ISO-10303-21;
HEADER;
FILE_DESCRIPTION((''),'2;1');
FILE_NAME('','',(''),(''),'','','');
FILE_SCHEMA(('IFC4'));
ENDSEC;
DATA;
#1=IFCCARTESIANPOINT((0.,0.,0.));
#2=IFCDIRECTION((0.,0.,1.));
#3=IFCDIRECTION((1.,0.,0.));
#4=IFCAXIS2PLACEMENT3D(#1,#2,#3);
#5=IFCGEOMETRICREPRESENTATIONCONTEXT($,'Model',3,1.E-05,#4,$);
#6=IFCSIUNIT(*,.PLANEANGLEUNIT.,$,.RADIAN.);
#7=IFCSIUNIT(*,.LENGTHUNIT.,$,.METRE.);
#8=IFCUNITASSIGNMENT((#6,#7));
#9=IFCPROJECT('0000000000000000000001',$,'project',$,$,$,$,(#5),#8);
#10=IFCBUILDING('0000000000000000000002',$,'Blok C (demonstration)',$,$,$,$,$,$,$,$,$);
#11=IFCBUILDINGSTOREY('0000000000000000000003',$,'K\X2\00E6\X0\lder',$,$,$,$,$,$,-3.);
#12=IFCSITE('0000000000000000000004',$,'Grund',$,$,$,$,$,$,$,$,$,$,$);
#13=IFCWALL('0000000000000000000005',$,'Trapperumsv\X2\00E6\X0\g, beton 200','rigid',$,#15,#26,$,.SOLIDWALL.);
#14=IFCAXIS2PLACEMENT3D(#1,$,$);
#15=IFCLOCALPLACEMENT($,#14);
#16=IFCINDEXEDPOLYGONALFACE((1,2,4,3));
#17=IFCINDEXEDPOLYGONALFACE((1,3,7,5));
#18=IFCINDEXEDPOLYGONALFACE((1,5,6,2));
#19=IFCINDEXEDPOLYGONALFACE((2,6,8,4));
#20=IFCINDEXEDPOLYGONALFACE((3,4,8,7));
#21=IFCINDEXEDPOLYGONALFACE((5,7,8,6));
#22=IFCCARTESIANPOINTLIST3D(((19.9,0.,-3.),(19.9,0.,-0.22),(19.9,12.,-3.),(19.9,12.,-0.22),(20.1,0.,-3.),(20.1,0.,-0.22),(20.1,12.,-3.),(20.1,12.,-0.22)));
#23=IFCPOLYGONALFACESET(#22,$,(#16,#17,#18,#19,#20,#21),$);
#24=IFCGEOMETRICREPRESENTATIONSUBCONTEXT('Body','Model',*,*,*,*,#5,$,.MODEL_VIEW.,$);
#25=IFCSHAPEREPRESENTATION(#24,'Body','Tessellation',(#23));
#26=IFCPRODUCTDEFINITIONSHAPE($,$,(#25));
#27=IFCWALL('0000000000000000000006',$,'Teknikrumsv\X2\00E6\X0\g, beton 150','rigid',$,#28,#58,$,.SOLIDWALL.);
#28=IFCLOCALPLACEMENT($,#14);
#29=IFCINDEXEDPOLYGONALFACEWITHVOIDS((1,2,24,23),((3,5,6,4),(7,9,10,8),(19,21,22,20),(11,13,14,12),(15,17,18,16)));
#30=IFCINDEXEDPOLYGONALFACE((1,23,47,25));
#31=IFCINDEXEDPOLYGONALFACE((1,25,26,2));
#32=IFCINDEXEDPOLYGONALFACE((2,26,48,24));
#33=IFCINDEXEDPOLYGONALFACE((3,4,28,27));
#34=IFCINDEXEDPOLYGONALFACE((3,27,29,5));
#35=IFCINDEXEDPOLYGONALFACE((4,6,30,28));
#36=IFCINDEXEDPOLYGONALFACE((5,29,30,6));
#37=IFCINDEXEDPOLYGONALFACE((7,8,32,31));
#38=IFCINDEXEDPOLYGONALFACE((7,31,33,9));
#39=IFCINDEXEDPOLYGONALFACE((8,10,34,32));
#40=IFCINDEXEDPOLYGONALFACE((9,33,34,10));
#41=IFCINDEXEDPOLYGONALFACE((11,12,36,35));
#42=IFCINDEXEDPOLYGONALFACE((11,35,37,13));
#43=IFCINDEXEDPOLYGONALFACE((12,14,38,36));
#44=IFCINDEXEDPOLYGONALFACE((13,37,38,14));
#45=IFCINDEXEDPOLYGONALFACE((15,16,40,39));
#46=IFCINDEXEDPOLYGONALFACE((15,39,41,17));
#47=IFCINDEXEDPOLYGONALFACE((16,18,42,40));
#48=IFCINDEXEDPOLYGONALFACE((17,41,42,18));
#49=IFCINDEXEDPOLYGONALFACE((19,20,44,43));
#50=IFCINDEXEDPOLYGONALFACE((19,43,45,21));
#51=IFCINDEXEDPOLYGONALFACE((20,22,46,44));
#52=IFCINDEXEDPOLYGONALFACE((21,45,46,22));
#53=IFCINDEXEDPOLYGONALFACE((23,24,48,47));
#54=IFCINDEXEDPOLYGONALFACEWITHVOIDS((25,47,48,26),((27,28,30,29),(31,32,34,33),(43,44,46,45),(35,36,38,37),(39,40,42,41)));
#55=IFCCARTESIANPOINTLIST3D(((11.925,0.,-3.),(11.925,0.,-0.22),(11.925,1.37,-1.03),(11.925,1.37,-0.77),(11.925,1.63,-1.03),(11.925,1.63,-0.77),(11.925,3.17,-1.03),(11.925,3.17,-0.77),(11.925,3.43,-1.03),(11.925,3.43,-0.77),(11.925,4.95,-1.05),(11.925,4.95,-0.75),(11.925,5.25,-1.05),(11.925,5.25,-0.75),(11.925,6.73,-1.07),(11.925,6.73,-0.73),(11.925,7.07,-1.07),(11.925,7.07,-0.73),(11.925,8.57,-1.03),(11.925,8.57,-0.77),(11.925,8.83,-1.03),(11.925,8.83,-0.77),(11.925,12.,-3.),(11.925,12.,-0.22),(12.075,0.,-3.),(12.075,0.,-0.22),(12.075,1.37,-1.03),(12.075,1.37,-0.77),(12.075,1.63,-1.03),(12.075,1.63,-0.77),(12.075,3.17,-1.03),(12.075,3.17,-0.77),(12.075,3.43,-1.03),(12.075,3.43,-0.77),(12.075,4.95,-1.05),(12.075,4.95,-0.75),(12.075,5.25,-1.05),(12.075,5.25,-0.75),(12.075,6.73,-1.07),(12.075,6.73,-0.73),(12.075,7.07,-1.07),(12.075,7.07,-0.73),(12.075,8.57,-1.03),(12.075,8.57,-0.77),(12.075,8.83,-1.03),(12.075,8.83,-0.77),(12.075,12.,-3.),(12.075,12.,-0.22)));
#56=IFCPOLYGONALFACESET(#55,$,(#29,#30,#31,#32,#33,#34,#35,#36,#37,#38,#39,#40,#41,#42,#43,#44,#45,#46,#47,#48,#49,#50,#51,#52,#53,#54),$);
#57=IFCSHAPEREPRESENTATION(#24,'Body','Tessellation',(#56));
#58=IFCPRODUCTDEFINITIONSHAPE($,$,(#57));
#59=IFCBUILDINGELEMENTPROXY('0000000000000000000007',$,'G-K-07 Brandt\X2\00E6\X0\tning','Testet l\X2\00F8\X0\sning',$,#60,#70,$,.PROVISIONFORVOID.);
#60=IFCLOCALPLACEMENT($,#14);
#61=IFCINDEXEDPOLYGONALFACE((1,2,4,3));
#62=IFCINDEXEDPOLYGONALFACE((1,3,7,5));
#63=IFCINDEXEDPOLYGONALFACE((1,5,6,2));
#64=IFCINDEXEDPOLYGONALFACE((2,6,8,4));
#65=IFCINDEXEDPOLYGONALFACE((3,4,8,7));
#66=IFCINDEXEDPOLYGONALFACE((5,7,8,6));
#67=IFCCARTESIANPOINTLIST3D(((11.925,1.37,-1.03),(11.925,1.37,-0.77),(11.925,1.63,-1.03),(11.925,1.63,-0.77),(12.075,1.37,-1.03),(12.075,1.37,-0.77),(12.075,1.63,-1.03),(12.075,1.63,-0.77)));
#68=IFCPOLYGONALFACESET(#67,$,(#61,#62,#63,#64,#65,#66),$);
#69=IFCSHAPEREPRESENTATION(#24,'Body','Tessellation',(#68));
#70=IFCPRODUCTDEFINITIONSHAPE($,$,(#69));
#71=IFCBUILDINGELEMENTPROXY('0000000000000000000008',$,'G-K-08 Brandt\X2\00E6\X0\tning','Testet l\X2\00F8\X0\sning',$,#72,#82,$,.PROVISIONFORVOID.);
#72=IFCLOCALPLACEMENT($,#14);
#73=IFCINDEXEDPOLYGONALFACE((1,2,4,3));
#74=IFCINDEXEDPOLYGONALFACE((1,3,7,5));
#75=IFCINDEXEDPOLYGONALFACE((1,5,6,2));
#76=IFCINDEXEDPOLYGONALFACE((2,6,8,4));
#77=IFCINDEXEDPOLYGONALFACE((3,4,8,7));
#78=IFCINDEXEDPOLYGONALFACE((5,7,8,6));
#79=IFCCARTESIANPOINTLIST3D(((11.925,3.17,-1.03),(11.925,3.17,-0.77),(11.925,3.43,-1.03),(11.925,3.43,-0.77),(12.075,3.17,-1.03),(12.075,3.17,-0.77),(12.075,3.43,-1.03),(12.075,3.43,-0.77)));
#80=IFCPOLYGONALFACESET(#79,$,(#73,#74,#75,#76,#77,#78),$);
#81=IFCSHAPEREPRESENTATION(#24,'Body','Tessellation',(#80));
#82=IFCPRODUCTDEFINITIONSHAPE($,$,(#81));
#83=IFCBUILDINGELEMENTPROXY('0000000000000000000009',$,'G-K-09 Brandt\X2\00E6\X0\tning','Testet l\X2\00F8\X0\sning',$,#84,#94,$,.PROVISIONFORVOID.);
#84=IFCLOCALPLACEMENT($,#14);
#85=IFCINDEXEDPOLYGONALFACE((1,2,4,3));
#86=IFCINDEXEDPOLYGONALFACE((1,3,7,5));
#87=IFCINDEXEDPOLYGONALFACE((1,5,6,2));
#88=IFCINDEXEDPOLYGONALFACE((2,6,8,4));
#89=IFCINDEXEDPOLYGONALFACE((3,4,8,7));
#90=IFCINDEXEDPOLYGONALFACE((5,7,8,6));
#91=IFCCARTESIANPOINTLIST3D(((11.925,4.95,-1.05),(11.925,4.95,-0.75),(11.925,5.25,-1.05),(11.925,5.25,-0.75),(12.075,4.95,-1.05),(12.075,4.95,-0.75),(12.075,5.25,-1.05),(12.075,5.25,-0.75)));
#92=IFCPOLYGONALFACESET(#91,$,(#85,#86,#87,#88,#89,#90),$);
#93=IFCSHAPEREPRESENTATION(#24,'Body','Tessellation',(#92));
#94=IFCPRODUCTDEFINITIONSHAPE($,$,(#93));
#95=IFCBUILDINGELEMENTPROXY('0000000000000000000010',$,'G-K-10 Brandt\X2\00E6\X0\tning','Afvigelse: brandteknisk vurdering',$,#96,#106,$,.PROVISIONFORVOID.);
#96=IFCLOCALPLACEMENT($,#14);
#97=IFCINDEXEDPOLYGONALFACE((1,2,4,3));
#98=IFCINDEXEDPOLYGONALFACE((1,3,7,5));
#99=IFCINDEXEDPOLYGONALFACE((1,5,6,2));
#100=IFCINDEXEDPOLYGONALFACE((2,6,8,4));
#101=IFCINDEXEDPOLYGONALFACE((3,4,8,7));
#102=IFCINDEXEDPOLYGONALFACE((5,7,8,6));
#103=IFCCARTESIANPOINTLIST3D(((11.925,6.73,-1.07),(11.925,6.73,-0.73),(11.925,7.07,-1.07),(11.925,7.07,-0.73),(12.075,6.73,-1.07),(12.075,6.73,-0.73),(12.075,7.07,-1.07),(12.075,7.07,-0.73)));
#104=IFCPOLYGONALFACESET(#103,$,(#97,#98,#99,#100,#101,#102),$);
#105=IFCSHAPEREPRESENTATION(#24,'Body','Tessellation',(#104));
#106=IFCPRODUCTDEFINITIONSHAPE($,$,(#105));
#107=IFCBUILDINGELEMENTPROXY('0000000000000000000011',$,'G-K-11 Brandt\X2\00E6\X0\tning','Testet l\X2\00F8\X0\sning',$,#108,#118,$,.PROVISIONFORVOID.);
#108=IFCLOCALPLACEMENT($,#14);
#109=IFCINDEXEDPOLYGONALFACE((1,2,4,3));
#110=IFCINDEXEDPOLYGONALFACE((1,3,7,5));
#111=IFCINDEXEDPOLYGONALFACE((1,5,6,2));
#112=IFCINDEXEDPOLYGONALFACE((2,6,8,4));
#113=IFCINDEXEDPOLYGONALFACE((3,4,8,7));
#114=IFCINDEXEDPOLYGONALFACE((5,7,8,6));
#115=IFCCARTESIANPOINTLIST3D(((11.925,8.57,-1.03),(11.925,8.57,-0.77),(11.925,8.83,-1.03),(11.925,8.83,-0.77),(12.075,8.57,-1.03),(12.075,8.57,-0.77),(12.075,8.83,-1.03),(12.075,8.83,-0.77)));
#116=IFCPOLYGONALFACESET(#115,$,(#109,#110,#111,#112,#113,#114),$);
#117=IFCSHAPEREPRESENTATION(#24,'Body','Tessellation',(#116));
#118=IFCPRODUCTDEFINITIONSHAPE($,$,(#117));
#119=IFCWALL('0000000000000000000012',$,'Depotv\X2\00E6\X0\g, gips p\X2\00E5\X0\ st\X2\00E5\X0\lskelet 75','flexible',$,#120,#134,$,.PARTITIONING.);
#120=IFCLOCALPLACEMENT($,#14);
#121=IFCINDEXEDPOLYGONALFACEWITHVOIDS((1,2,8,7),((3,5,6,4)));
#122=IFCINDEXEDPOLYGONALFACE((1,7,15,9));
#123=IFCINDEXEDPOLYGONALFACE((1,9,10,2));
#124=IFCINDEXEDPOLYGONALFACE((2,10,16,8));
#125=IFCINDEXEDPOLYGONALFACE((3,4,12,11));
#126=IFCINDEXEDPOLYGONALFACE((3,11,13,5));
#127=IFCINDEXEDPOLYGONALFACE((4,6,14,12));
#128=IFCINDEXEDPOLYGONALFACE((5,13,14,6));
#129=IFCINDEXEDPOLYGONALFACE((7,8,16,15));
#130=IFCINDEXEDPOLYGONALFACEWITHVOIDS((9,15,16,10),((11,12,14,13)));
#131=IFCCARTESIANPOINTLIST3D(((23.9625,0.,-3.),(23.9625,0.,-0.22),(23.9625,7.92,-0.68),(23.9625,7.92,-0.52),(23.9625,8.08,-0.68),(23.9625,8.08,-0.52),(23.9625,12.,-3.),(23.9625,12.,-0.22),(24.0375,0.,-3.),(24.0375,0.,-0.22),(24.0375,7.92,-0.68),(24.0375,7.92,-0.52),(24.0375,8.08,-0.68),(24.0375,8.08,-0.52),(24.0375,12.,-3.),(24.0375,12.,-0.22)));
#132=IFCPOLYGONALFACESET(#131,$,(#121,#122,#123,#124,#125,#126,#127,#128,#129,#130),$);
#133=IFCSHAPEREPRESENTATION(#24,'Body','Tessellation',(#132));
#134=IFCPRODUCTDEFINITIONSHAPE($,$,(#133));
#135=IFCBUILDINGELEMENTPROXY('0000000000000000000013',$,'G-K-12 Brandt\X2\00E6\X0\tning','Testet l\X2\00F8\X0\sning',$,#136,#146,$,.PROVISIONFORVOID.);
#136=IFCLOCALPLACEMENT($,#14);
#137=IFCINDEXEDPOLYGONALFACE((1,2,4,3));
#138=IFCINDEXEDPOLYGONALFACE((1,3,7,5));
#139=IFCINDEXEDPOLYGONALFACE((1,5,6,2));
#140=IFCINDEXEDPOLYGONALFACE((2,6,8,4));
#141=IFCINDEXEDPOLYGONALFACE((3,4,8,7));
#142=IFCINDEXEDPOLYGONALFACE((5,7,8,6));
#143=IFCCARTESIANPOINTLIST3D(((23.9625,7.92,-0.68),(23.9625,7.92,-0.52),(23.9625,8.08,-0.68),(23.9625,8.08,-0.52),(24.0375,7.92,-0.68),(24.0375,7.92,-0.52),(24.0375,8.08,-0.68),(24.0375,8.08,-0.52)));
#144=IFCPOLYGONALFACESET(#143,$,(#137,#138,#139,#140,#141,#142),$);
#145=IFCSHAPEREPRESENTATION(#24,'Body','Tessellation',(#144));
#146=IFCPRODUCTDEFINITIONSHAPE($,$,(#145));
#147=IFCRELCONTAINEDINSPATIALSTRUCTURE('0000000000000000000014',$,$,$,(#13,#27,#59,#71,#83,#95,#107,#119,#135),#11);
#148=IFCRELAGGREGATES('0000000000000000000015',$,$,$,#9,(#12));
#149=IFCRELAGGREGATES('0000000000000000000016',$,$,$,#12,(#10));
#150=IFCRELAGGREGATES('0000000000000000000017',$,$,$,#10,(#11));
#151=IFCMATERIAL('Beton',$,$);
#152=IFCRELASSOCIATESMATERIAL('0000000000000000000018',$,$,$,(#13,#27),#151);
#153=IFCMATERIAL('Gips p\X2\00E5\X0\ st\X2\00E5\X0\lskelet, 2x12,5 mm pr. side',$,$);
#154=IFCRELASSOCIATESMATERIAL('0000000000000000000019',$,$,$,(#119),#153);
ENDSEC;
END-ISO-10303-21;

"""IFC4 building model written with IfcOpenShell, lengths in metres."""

from ifc_helpers import new_model, si_unit, frame, origin_with_axes, place, context, subcontext, project, spatial, polyline, outline, extrude, material, element, fill, save


model = new_model("IFC4")

# Units and contexts
model_context = context("Model", 3, precision=1e-05, world=origin_with_axes())
body_context = subcontext(model_context, "Body", "Model", "MODEL_VIEW")
ifc_project = project(units=[si_unit("PLANEANGLEUNIT", "RADIAN"), si_unit("LENGTHUNIT", "METRE")], contexts=[model_context])

# Site, building, storey
site = spatial("IfcSite", under=ifc_project, Name="Grund")
building = spatial("IfcBuilding", under=site, Name="Blok C (demonstration)")
storey = spatial("IfcBuildingStorey", under=building, Name="Kælder", Elevation=-3.0)

# Wall
ifc_material_1 = material(Name="Beton")
wall_1_placement = place(None, origin_with_axes())
element("IfcWall", 1, at=wall_1_placement, inside=storey, material=ifc_material_1, Name="Trapperumsvæg, beton 200", Description="rigid", PredefinedType="SOLIDWALL", context=body_context, shape_type="SweptSolid", body=[
    extrude(outline(polyline([(19.9, 0.0), (20.1, 0.0), (20.1, 12.0), (19.9, 12.0), (19.9, 0.0)])), frame((0.0, 0.0, -3.0)), (0.0, 0.0, 1.0), 2.78),
])

# Wall, openings, building element proxies
wall_2_placement = place(None, origin_with_axes())
wall_2 = element("IfcWall", 2, at=wall_2_placement, inside=storey, material=ifc_material_1, Name="Teknikrumsvæg, beton 150", Description="rigid", PredefinedType="SOLIDWALL", context=body_context, shape_type="SweptSolid", body=[
    extrude(outline(polyline([(11.925, 0.0), (12.075, 0.0), (12.075, 12.0), (11.925, 12.0), (11.925, 0.0)])), frame((0.0, 0.0, -3.0)), (0.0, 0.0, 1.0), 2.78),
])
opening_1_placement = place(wall_2_placement, origin_with_axes())
opening_1 = element("IfcOpeningElement", 3, at=opening_1_placement, cuts=wall_2, PredefinedType="OPENING", context=body_context, shape_type="SweptSolid", body=[
    extrude(outline(polyline([(11.88, 1.37), (12.12, 1.37), (12.12, 1.63), (11.88, 1.63), (11.88, 1.37)])), frame((0.0, 0.0, -1.03)), (0.0, 0.0, 1.0), 0.26),
])
opening_2_placement = place(wall_2_placement, origin_with_axes())
opening_2 = element("IfcOpeningElement", 4, at=opening_2_placement, cuts=wall_2, PredefinedType="OPENING", context=body_context, shape_type="SweptSolid", body=[
    extrude(outline(polyline([(11.88, 3.17), (12.12, 3.17), (12.12, 3.43), (11.88, 3.43), (11.88, 3.17)])), frame((0.0, 0.0, -1.03)), (0.0, 0.0, 1.0), 0.26),
])
opening_3_placement = place(wall_2_placement, origin_with_axes())
opening_3 = element("IfcOpeningElement", 5, at=opening_3_placement, cuts=wall_2, PredefinedType="OPENING", context=body_context, shape_type="SweptSolid", body=[
    extrude(outline(polyline([(11.88, 4.95), (12.12, 4.95), (12.12, 5.25), (11.88, 5.25), (11.88, 4.95)])), frame((0.0, 0.0, -1.05)), (0.0, 0.0, 1.0), 0.3),
])
opening_4_placement = place(wall_2_placement, origin_with_axes())
opening_4 = element("IfcOpeningElement", 6, at=opening_4_placement, cuts=wall_2, PredefinedType="OPENING", context=body_context, shape_type="SweptSolid", body=[
    extrude(outline(polyline([(11.88, 6.73), (12.12, 6.73), (12.12, 7.07), (11.88, 7.07), (11.88, 6.73)])), frame((0.0, 0.0, -1.07)), (0.0, 0.0, 1.0), 0.34),
])
opening_5_placement = place(wall_2_placement, origin_with_axes())
opening_5 = element("IfcOpeningElement", 7, at=opening_5_placement, cuts=wall_2, PredefinedType="OPENING", context=body_context, shape_type="SweptSolid", body=[
    extrude(outline(polyline([(11.88, 8.57), (12.12, 8.57), (12.12, 8.83), (11.88, 8.83), (11.88, 8.57)])), frame((0.0, 0.0, -1.03)), (0.0, 0.0, 1.0), 0.26),
])
proxy_1_placement = place(None, origin_with_axes())
proxy_1 = element("IfcBuildingElementProxy", 8, at=proxy_1_placement, inside=storey, Name="G-K-07 Brandtætning", Description="Testet løsning", PredefinedType="PROVISIONFORVOID", context=body_context, shape_type="SweptSolid", body=[
    extrude(outline(polyline([(11.925, 1.37), (12.075, 1.37), (12.075, 1.63), (11.925, 1.63), (11.925, 1.37)])), frame((0.0, 0.0, -1.03)), (0.0, 0.0, 1.0), 0.26),
])
fill(opening_1, proxy_1)
proxy_2_placement = place(None, origin_with_axes())
proxy_2 = element("IfcBuildingElementProxy", 9, at=proxy_2_placement, inside=storey, Name="G-K-08 Brandtætning", Description="Testet løsning", PredefinedType="PROVISIONFORVOID", context=body_context, shape_type="SweptSolid", body=[
    extrude(outline(polyline([(11.925, 3.17), (12.075, 3.17), (12.075, 3.43), (11.925, 3.43), (11.925, 3.17)])), frame((0.0, 0.0, -1.03)), (0.0, 0.0, 1.0), 0.26),
])
fill(opening_2, proxy_2)
proxy_3_placement = place(None, origin_with_axes())
proxy_3 = element("IfcBuildingElementProxy", 10, at=proxy_3_placement, inside=storey, Name="G-K-09 Brandtætning", Description="Testet løsning", PredefinedType="PROVISIONFORVOID", context=body_context, shape_type="SweptSolid", body=[
    extrude(outline(polyline([(11.925, 4.95), (12.075, 4.95), (12.075, 5.25), (11.925, 5.25), (11.925, 4.95)])), frame((0.0, 0.0, -1.05)), (0.0, 0.0, 1.0), 0.3),
])
fill(opening_3, proxy_3)
proxy_4_placement = place(None, origin_with_axes())
proxy_4 = element("IfcBuildingElementProxy", 11, at=proxy_4_placement, inside=storey, Name="G-K-10 Brandtætning", Description="Afvigelse: brandteknisk vurdering", PredefinedType="PROVISIONFORVOID", context=body_context, shape_type="SweptSolid", body=[
    extrude(outline(polyline([(11.925, 6.73), (12.075, 6.73), (12.075, 7.07), (11.925, 7.07), (11.925, 6.73)])), frame((0.0, 0.0, -1.07)), (0.0, 0.0, 1.0), 0.34),
])
fill(opening_4, proxy_4)
proxy_5_placement = place(None, origin_with_axes())
proxy_5 = element("IfcBuildingElementProxy", 12, at=proxy_5_placement, inside=storey, Name="G-K-11 Brandtætning", Description="Testet løsning", PredefinedType="PROVISIONFORVOID", context=body_context, shape_type="SweptSolid", body=[
    extrude(outline(polyline([(11.925, 8.57), (12.075, 8.57), (12.075, 8.83), (11.925, 8.83), (11.925, 8.57)])), frame((0.0, 0.0, -1.03)), (0.0, 0.0, 1.0), 0.26),
])
fill(opening_5, proxy_5)

# Wall, opening, building element proxy
ifc_material_2 = material(Name="Gips på stålskelet, 2x12,5 mm pr. side")
wall_3_placement = place(None, origin_with_axes())
wall_3 = element("IfcWall", 13, at=wall_3_placement, inside=storey, material=ifc_material_2, Name="Depotvæg, gips på stålskelet 75", Description="flexible", PredefinedType="PARTITIONING", context=body_context, shape_type="SweptSolid", body=[
    extrude(outline(polyline([(23.9625, 0.0), (24.0375, 0.0), (24.0375, 12.0), (23.9625, 12.0), (23.9625, 0.0)])), frame((0.0, 0.0, -3.0)), (0.0, 0.0, 1.0), 2.78),
])
opening_6_placement = place(wall_3_placement, origin_with_axes())
opening_6 = element("IfcOpeningElement", 14, at=opening_6_placement, cuts=wall_3, PredefinedType="OPENING", context=body_context, shape_type="SweptSolid", body=[
    extrude(outline(polyline([(23.88, 7.92), (24.12, 7.92), (24.12, 8.08), (23.88, 8.08), (23.88, 7.92)])), frame((0.0, 0.0, -0.68)), (0.0, 0.0, 1.0), 0.16),
])
proxy_6_placement = place(None, origin_with_axes())
proxy_6 = element("IfcBuildingElementProxy", 15, at=proxy_6_placement, inside=storey, Name="G-K-12 Brandtætning", Description="Testet løsning", PredefinedType="PROVISIONFORVOID", context=body_context, shape_type="SweptSolid", body=[
    extrude(outline(polyline([(23.9625, 7.92), (24.0375, 7.92), (24.0375, 8.08), (23.9625, 8.08), (23.9625, 7.92)])), frame((0.0, 0.0, -0.68)), (0.0, 0.0, 1.0), 0.16),
])
fill(opening_6, proxy_6)

save(model, "model.ifc")
